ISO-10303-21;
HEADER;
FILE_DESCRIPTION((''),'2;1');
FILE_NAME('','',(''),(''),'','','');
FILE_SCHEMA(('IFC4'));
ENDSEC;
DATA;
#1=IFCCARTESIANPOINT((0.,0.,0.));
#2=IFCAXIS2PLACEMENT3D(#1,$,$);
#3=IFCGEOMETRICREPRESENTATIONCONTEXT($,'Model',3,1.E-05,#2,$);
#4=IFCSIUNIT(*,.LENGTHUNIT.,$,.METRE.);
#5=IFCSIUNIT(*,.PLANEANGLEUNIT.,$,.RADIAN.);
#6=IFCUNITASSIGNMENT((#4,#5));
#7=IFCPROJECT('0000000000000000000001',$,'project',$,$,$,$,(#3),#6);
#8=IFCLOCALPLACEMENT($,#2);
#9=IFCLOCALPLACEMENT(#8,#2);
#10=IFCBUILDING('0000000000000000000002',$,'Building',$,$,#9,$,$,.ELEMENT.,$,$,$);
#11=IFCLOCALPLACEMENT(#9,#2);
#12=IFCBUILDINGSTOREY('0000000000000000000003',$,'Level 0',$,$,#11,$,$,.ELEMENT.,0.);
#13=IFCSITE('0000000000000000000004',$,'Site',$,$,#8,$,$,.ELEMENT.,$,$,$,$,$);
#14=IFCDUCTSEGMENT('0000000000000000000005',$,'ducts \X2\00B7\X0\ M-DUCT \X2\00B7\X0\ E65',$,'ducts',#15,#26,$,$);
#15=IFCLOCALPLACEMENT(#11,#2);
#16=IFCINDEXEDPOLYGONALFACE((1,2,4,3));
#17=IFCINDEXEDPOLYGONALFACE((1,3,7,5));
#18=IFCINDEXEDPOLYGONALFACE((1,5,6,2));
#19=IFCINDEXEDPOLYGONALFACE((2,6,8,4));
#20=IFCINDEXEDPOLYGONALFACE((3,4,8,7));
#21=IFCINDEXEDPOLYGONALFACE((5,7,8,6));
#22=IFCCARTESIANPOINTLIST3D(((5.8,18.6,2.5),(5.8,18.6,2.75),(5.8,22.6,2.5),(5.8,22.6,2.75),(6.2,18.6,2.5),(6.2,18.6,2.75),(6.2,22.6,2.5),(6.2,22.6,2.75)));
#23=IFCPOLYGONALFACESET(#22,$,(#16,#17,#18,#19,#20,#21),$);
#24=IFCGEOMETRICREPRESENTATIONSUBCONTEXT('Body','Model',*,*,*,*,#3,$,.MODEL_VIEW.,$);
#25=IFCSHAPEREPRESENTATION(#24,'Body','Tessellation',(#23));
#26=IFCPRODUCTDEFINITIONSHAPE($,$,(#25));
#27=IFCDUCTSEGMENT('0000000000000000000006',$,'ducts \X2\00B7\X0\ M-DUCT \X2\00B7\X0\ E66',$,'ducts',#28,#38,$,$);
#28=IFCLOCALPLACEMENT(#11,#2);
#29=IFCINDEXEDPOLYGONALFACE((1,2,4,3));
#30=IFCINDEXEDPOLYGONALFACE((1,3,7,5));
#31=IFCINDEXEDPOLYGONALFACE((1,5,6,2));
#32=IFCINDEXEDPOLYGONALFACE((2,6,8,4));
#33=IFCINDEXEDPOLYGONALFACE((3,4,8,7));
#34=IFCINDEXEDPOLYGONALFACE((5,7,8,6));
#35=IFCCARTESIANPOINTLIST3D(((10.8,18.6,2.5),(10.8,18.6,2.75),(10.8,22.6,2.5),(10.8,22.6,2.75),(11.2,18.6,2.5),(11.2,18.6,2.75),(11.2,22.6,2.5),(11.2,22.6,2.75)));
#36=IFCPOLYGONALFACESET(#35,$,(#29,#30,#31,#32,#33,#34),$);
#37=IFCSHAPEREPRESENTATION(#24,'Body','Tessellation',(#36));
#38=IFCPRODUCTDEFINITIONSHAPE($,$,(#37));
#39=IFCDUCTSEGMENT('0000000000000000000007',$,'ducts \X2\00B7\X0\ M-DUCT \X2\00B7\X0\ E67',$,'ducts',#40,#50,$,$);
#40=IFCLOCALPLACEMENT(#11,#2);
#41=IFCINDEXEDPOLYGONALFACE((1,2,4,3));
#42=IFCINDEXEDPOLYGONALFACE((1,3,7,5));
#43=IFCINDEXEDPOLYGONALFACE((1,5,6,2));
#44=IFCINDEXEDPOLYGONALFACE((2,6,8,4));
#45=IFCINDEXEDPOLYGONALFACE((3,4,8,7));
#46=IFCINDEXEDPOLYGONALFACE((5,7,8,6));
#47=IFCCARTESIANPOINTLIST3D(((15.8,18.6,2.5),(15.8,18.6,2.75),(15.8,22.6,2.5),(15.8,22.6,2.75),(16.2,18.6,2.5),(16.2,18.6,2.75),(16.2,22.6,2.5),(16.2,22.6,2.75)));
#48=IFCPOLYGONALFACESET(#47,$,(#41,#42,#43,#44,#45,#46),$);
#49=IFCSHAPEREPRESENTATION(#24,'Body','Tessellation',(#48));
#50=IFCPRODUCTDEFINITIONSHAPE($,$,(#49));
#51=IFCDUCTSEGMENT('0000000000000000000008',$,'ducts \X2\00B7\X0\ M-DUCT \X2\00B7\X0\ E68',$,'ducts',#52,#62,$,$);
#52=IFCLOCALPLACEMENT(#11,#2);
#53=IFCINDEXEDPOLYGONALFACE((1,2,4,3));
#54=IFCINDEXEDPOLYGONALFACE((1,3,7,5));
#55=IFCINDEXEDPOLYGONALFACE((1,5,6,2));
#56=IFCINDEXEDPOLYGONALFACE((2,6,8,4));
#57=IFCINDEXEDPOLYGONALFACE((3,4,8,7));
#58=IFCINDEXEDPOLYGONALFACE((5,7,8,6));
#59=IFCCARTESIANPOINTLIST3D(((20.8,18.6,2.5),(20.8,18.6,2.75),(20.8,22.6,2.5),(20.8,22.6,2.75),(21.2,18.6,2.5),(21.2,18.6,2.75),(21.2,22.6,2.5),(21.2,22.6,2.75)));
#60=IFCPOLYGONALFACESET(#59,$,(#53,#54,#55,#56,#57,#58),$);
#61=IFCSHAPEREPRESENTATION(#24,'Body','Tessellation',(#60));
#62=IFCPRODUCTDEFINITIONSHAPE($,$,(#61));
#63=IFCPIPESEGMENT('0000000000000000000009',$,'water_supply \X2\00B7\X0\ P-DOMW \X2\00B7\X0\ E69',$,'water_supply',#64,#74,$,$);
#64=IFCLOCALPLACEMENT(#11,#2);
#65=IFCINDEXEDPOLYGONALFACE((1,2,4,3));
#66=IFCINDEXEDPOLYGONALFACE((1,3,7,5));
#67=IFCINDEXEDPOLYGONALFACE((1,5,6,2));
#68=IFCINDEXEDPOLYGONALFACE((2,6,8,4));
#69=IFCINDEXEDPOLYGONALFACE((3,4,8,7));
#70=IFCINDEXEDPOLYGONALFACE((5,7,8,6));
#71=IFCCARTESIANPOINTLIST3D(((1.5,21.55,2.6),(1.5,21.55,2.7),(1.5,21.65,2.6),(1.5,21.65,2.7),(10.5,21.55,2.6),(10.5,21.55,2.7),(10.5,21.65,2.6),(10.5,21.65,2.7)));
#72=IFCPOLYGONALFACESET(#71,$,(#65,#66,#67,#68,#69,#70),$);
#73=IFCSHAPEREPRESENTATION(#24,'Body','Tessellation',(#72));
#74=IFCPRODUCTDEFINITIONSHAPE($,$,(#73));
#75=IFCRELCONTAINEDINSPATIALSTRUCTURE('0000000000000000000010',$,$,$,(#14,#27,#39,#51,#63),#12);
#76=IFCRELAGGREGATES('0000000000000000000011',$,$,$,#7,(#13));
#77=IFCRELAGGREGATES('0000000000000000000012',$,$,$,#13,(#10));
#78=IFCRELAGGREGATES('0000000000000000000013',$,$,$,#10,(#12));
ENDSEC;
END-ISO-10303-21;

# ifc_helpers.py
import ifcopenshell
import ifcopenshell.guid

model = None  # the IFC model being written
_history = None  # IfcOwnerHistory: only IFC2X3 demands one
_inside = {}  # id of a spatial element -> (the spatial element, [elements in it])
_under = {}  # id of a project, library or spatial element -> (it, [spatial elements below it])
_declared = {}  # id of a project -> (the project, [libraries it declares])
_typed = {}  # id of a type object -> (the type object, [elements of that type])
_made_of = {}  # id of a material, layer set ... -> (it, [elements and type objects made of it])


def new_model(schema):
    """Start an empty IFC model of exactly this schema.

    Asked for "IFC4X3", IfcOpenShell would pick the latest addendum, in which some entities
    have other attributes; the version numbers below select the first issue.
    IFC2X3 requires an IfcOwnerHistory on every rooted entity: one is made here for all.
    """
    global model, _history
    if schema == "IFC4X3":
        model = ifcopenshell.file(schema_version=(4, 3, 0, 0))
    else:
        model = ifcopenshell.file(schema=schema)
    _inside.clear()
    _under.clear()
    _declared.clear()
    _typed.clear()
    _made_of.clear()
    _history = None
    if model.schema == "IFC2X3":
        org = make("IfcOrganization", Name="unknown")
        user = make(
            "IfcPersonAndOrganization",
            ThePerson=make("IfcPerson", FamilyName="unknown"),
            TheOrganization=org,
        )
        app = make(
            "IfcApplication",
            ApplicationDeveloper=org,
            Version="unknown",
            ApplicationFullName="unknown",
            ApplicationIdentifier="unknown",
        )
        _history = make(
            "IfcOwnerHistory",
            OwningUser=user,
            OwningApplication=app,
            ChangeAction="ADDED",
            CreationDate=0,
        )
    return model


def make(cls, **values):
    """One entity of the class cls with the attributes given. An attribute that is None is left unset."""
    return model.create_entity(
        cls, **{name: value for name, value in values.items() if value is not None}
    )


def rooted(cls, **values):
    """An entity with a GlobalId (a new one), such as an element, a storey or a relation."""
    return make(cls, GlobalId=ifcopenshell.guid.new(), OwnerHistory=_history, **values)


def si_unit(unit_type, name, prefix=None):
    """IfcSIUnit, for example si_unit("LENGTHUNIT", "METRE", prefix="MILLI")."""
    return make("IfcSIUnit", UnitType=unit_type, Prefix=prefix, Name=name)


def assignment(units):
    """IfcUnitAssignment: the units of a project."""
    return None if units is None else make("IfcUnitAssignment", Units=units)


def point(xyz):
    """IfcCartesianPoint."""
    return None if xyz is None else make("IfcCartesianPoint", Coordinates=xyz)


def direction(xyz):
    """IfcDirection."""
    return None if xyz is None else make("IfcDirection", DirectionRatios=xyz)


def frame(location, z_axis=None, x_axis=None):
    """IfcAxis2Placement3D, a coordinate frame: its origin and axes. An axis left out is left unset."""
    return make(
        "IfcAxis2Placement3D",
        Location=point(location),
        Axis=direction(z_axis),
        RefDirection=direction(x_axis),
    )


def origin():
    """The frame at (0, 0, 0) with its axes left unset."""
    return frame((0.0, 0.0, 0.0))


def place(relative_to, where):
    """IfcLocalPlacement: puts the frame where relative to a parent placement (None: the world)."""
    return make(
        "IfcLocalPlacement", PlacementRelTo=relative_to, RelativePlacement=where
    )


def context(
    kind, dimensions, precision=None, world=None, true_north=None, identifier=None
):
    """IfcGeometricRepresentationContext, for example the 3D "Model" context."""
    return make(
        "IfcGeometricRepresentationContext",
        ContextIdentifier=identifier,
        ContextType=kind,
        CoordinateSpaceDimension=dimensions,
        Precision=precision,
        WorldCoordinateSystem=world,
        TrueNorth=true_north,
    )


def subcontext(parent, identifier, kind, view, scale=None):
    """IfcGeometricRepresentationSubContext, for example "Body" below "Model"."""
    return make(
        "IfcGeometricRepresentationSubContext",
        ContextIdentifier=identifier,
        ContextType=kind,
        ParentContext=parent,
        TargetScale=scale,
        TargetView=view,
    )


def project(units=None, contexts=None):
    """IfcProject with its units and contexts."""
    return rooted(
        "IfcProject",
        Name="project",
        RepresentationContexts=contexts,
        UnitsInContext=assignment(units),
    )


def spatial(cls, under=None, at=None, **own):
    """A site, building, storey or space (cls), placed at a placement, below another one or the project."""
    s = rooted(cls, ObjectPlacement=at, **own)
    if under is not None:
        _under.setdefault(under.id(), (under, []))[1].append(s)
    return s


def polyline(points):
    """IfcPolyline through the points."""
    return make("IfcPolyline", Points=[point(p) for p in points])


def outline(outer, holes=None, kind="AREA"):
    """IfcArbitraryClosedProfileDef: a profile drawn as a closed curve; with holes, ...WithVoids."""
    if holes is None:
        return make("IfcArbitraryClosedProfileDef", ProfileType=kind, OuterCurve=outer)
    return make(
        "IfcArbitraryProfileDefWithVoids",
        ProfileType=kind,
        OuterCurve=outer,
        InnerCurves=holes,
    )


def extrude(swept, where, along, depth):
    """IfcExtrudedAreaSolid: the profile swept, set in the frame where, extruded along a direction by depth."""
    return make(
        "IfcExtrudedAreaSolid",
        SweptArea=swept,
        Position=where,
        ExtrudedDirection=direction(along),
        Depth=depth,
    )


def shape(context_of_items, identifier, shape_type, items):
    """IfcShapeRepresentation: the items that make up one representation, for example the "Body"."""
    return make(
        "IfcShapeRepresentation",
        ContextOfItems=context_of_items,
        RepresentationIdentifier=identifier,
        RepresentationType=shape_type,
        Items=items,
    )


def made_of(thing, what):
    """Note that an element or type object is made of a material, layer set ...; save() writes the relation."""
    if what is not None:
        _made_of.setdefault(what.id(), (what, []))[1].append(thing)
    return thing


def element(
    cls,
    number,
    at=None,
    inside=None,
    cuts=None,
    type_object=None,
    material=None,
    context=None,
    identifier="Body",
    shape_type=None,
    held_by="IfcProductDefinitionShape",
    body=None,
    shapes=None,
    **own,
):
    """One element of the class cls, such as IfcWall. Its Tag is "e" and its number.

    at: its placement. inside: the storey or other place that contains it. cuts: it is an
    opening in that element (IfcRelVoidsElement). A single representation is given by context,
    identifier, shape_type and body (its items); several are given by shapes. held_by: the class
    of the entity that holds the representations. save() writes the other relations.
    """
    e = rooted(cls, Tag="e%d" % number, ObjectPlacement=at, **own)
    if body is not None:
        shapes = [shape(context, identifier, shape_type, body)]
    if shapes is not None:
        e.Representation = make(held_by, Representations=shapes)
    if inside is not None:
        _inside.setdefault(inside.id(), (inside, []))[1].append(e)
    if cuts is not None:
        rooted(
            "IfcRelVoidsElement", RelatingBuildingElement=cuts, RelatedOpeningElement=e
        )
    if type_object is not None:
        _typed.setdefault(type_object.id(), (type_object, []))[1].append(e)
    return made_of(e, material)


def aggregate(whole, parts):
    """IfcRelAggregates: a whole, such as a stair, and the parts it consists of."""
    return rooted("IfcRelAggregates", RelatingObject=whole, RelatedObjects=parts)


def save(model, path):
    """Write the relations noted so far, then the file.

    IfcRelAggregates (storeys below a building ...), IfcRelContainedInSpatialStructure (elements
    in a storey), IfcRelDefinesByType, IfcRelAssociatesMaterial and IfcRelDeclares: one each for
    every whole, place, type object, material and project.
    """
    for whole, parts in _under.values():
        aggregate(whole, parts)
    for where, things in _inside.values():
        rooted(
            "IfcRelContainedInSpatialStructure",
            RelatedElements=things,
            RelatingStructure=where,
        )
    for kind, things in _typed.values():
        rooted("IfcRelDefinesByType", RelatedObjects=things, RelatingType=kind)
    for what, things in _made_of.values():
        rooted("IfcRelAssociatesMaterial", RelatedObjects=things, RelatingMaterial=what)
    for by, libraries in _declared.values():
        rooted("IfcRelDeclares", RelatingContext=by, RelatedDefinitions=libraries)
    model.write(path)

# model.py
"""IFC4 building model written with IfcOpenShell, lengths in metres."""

from ifc_helpers import new_model, si_unit, frame, origin, place, context, subcontext, project, spatial, polyline, outline, extrude, element, save


model = new_model("IFC4")

# Units and contexts
model_context = context("Model", 3, precision=1e-05, world=origin())
body_context = subcontext(model_context, "Body", "Model", "MODEL_VIEW")
ifc_project = project(units=[si_unit("LENGTHUNIT", "METRE"), si_unit("PLANEANGLEUNIT", "RADIAN")], contexts=[model_context])

# Site, building, storey
site_placement = place(None, origin())
site = spatial("IfcSite", under=ifc_project, at=site_placement, Name="Site", CompositionType="ELEMENT")
building_placement = place(site_placement, origin())
building = spatial("IfcBuilding", under=site, at=building_placement, Name="Building", CompositionType="ELEMENT")
storey_placement = place(building_placement, origin())
storey = spatial("IfcBuildingStorey", under=building, at=storey_placement, Name="Level 0", CompositionType="ELEMENT", Elevation=0.0)

# Duct segments
duct_segment_1_placement = place(storey_placement, frame((0.0, 0.0, 2.5)))
element("IfcDuctSegment", 1, at=duct_segment_1_placement, inside=storey, Name="ducts · M-DUCT · E65", ObjectType="ducts", context=body_context, shape_type="SweptSolid", body=[
    extrude(outline(polyline([(5.8, 22.6), (5.8, 18.6), (6.2, 18.6), (6.2, 22.6), (5.8, 22.6)])), origin(), (0.0, 0.0, 1.0), 0.25),
])
duct_segment_2_placement = place(storey_placement, frame((0.0, 0.0, 2.5)))
element("IfcDuctSegment", 2, at=duct_segment_2_placement, inside=storey, Name="ducts · M-DUCT · E66", ObjectType="ducts", context=body_context, shape_type="SweptSolid", body=[
    extrude(outline(polyline([(10.8, 22.6), (10.8, 18.6), (11.2, 18.6), (11.2, 22.6), (10.8, 22.6)])), origin(), (0.0, 0.0, 1.0), 0.25),
])
duct_segment_3_placement = place(storey_placement, frame((0.0, 0.0, 2.5)))
element("IfcDuctSegment", 3, at=duct_segment_3_placement, inside=storey, Name="ducts · M-DUCT · E67", ObjectType="ducts", context=body_context, shape_type="SweptSolid", body=[
    extrude(outline(polyline([(15.8, 22.6), (15.8, 18.6), (16.2, 18.6), (16.2, 22.6), (15.8, 22.6)])), origin(), (0.0, 0.0, 1.0), 0.25),
])
duct_segment_4_placement = place(storey_placement, frame((0.0, 0.0, 2.5)))
element("IfcDuctSegment", 4, at=duct_segment_4_placement, inside=storey, Name="ducts · M-DUCT · E68", ObjectType="ducts", context=body_context, shape_type="SweptSolid", body=[
    extrude(outline(polyline([(20.8, 22.6), (20.8, 18.6), (21.2, 18.6), (21.2, 22.6), (20.8, 22.6)])), origin(), (0.0, 0.0, 1.0), 0.25),
])

# Pipe segment
pipe_segment_placement = place(storey_placement, frame((0.0, 0.0, 2.6)))
element("IfcPipeSegment", 5, at=pipe_segment_placement, inside=storey, Name="water_supply · P-DOMW · E69", ObjectType="water_supply", context=body_context, shape_type="SweptSolid", body=[
    extrude(outline(polyline([(1.5, 21.55), (10.5, 21.55), (10.5, 21.65), (1.5, 21.65), (1.5, 21.55)])), origin(), (0.0, 0.0, 1.0), 0.1),
])

save(model, "model.ifc")
